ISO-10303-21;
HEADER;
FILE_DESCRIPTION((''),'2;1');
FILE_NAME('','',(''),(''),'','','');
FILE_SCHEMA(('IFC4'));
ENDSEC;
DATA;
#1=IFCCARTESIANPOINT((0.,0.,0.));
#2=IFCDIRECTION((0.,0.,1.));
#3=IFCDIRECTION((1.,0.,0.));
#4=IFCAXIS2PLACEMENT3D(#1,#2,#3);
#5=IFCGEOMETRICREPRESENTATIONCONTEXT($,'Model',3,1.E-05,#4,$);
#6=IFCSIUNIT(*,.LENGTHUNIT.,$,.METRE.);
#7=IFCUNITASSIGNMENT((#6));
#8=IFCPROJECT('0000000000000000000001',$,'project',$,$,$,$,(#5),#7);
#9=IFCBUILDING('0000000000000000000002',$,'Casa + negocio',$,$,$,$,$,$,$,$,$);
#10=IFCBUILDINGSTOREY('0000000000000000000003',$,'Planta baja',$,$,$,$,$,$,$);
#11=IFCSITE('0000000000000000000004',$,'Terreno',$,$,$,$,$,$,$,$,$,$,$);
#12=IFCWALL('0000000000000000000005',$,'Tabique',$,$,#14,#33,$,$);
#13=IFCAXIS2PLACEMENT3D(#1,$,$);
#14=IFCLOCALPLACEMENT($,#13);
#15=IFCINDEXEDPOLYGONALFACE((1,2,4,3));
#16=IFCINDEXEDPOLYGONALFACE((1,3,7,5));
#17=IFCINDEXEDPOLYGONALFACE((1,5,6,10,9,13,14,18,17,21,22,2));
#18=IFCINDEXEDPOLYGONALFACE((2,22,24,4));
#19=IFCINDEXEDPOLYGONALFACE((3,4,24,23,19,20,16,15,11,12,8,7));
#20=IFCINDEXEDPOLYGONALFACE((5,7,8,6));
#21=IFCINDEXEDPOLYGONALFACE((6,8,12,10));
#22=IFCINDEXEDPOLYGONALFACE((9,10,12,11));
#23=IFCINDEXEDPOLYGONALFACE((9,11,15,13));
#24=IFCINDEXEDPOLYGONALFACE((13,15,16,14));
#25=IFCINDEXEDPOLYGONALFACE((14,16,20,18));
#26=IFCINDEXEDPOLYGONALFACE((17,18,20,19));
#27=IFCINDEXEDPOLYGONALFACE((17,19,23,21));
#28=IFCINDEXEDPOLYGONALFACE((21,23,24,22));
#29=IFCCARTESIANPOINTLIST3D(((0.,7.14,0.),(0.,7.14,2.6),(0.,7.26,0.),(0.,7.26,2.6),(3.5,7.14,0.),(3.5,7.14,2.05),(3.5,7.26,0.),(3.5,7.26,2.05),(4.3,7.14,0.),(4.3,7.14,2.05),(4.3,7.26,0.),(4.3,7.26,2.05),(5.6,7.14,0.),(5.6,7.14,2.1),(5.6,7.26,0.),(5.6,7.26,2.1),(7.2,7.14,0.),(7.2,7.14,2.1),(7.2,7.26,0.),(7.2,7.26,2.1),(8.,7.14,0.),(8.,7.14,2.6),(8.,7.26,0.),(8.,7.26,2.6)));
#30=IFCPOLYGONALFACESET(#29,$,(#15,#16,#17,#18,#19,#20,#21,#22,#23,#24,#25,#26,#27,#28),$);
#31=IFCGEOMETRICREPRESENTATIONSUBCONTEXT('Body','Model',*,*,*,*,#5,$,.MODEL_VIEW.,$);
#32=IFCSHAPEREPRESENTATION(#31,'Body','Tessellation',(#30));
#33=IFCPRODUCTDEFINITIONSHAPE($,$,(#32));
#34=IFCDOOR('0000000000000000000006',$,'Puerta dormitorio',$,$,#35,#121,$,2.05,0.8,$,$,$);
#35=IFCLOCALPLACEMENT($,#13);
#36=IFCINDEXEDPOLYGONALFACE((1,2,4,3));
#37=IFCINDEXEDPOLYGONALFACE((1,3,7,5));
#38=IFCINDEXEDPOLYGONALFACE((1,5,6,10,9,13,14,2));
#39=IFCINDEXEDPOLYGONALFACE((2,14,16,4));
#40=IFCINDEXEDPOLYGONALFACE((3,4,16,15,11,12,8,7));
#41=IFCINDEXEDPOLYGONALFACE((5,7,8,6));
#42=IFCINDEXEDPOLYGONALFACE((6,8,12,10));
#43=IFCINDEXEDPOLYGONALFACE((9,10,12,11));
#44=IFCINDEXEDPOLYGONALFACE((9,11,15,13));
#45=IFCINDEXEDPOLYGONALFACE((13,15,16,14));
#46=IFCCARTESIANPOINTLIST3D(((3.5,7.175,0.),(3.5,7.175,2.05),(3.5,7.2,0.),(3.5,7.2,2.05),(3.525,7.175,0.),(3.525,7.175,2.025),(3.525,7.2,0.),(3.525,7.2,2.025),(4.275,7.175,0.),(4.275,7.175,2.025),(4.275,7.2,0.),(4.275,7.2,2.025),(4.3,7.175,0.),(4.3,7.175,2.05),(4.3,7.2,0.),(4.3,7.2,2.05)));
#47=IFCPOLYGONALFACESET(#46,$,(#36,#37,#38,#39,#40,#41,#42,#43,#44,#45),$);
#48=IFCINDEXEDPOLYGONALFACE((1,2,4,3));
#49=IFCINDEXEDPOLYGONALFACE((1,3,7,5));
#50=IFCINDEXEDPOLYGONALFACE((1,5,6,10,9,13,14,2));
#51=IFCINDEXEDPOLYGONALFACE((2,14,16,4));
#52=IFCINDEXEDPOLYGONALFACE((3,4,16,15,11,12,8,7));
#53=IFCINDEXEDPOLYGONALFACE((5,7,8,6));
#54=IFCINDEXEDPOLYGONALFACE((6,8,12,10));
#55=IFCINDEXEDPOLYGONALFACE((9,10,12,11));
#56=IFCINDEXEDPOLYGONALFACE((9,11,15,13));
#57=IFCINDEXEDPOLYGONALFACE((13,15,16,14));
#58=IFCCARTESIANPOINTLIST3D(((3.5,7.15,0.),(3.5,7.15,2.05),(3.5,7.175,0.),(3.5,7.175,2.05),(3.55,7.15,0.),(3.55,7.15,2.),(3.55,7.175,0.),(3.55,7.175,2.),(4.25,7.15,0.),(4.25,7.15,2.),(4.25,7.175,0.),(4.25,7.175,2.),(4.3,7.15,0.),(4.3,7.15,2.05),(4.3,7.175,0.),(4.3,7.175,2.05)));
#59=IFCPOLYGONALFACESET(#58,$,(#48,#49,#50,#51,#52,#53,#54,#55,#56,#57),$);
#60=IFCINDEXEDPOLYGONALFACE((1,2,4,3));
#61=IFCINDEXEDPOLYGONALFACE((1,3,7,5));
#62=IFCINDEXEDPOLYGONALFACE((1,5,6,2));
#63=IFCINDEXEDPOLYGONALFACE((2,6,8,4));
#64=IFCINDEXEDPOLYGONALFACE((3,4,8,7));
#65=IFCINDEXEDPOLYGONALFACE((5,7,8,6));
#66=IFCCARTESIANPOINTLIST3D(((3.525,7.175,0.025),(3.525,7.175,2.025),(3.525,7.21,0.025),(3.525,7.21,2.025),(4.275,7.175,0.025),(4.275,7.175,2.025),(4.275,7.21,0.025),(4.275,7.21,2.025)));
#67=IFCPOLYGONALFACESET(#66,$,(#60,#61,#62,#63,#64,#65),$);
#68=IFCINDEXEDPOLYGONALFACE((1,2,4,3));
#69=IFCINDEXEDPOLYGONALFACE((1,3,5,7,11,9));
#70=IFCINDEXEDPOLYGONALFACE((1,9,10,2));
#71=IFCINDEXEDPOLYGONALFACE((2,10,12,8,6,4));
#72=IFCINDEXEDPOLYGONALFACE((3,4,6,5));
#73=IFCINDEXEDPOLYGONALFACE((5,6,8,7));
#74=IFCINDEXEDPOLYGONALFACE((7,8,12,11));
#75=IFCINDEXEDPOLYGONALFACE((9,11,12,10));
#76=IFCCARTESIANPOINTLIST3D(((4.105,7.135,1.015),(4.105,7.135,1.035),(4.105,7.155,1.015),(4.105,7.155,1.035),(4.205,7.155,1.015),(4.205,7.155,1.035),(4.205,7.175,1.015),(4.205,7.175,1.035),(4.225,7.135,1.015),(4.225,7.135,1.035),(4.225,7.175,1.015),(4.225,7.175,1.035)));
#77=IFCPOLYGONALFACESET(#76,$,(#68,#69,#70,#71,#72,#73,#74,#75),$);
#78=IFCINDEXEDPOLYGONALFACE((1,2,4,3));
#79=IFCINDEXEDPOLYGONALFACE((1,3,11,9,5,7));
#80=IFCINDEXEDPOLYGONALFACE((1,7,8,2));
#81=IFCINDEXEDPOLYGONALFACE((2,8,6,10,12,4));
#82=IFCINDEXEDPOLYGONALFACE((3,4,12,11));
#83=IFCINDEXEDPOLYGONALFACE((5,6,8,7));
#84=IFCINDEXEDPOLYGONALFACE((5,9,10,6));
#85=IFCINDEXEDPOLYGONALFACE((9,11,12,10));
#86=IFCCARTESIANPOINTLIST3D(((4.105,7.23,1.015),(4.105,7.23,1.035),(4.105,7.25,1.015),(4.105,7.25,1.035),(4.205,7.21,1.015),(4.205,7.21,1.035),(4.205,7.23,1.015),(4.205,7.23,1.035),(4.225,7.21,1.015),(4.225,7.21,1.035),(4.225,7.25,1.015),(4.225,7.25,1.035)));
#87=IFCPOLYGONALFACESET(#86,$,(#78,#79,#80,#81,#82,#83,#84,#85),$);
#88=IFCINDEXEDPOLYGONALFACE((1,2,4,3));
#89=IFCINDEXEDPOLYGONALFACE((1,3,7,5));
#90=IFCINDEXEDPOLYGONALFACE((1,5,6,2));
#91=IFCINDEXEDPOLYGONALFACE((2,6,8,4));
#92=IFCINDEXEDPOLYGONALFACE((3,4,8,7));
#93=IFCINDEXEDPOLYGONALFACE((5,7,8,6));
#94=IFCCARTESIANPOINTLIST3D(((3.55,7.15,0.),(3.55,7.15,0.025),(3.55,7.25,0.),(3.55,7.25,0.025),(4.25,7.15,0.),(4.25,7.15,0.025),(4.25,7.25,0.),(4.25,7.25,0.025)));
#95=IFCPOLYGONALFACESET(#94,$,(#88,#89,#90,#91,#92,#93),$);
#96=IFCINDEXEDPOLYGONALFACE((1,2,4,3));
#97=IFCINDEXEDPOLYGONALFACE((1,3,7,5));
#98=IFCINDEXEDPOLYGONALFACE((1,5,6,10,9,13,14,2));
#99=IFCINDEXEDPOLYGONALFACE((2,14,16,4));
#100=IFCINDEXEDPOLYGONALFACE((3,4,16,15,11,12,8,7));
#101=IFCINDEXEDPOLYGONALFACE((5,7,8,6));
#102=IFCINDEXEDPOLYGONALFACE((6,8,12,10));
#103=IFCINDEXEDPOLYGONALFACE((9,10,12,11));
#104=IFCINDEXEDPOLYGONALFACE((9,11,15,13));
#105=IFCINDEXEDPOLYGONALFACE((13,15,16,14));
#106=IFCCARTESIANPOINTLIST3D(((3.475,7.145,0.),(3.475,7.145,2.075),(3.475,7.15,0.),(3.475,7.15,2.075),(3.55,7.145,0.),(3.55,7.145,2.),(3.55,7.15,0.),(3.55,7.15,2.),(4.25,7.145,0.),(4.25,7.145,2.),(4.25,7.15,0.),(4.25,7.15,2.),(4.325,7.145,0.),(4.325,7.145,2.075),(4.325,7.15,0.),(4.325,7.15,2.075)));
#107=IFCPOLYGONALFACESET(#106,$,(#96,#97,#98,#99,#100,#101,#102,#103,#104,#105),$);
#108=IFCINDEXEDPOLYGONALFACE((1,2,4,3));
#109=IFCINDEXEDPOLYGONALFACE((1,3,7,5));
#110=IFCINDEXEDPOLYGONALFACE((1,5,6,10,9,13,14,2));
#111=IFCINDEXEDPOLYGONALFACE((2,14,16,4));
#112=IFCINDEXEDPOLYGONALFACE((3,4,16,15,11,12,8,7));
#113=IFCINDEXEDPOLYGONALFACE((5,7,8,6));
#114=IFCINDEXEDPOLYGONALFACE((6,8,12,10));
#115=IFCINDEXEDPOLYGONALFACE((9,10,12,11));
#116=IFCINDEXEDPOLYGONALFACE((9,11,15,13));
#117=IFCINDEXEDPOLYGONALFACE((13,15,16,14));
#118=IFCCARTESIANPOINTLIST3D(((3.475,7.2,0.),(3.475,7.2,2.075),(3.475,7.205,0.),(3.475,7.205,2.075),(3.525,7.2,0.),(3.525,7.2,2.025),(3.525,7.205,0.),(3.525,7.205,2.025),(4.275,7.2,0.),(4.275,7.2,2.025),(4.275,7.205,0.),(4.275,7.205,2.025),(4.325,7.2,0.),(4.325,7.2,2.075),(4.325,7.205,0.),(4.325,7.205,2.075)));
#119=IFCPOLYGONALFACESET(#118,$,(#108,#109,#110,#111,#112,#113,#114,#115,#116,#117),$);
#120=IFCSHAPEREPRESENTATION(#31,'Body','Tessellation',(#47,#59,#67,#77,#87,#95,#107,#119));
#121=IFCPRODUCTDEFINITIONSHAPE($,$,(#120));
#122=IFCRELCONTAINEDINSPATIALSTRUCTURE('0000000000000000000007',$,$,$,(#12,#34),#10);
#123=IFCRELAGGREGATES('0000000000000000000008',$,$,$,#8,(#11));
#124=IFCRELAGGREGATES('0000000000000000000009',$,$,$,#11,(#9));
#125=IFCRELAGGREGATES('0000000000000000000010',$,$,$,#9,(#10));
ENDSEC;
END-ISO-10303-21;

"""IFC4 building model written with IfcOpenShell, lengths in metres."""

from ifc_helpers import new_model, si_unit, frame, origin_with_axes, place, context, subcontext, project, spatial, line, indexed_curve, outline, extrude, element, fill, save


model = new_model("IFC4")

# Units and contexts
model_context = context("Model", 3, precision=1e-05, world=origin_with_axes())
body_context = subcontext(model_context, "Body", "Model", "MODEL_VIEW")
ifc_project = project(units=[si_unit("LENGTHUNIT", "METRE")], contexts=[model_context])

# Site, building, storey
site = spatial("IfcSite", under=ifc_project, Name="Terreno")
building = spatial("IfcBuilding", under=site, Name="Casa + negocio")
storey = spatial("IfcBuildingStorey", under=building, Name="Planta baja")

# Wall, openings, door
wall_1_placement = place(None, frame((0.0, 7.2, 0.0), z_axis=(0.0, 0.0, 1.0), x_axis=(1.0, 0.0, 0.0)))
wall_1 = element("IfcWall", 1, at=wall_1_placement, inside=storey, Name="Tabique", context=body_context, shape_type="SweptSolid", body=[
    extrude(outline(indexed_curve([(0.0, 0.0), (0.0, 0.12), (8.0, 0.12), (8.0, 0.0), (0.0, 0.0)], self_intersect=False)), frame((0.0, -0.06, 0.0), z_axis=(0.0, 0.0, 1.0), x_axis=(1.0, 0.0, 0.0)), (0.0, 0.0, 1.0), 2.6),
])
opening_1_placement = place(wall_1_placement, frame((3.5, 0.0, 0.0), z_axis=(0.0, 0.0, 1.0), x_axis=(1.0, 0.0, 0.0)))
opening_1 = element("IfcOpeningElement", 2, at=opening_1_placement, cuts=wall_1, context=body_context, shape_type="SweptSolid", body=[
    extrude(outline(indexed_curve([(0.0, 0.0), (0.0, 0.22), (0.8, 0.22), (0.8, 0.0), (0.0, 0.0)], self_intersect=False)), frame((0.0, -0.11, 0.0), z_axis=(0.0, 0.0, 1.0), x_axis=(1.0, 0.0, 0.0)), (0.0, 0.0, 1.0), 2.05),
])
opening_2_placement = place(wall_1_placement, frame((5.6, 0.0, 0.0), z_axis=(0.0, 0.0, 1.0), x_axis=(1.0, 0.0, 0.0)))
element("IfcOpeningElement", 3, at=opening_2_placement, cuts=wall_1, context=body_context, shape_type="SweptSolid", body=[
    extrude(outline(indexed_curve([(0.0, 0.0), (0.0, 0.22), (1.6, 0.22), (1.6, 0.0), (0.0, 0.0)], self_intersect=False)), frame((0.0, -0.11, 0.0), z_axis=(0.0, 0.0, 1.0), x_axis=(1.0, 0.0, 0.0)), (0.0, 0.0, 1.0), 2.1),
])
door_1_placement = place(opening_1_placement, frame((0.0, -0.05, 0.0), z_axis=(0.0, 0.0, 1.0), x_axis=(1.0, 0.0, 0.0)))
door_1 = element("IfcDoor", 4, at=door_1_placement, inside=storey, Name="Puerta dormitorio", OverallHeight=2.05, OverallWidth=0.8, context=body_context, shape_type="SweptSolid", body=[
    extrude(outline(indexed_curve([(0.0, 0.0), (0.0, 2.05), (0.8, 2.05), (0.8, 0.0), (0.775, 0.0), (0.775, 2.025), (0.025, 2.025), (0.025, 0.0)], segments=[line(1, 2, 3, 4, 5, 6, 7, 8, 1)])), frame((0.0, 0.025, 0.0), z_axis=(0.0, -1.0, 0.0), x_axis=(1.0, 0.0, 0.0)), (0.0, 0.0, -1.0), 0.025),
    extrude(outline(indexed_curve([(0.0, 0.0), (0.0, 2.05), (0.8, 2.05), (0.8, 0.0), (0.75, 0.0), (0.75, 2.0), (0.05, 2.0), (0.05, 0.0)], segments=[line(1, 2, 3, 4, 5, 6, 7, 8, 1)])), frame((0.0, 0.0, 0.0), z_axis=(0.0, -1.0, 0.0), x_axis=(1.0, 0.0, 0.0)), (0.0, 0.0, -1.0), 0.025),
    extrude(outline(indexed_curve([(0.0, 0.0), (0.75, 0.0), (0.75, 0.035), (0.0, 0.035)], segments=[line(1, 2, 3, 4, 1)])), frame((0.025, 0.025, 0.025), z_axis=(0.0, 0.0, 1.0), x_axis=(1.0, 0.0, 0.0)), (0.0, 0.0, 1.0), 2.0),
    extrude(outline(indexed_curve([(0.0, 0.0), (0.0, -0.04), (-0.12, -0.04), (-0.12, -0.02), (-0.02, -0.02), (-0.02, 0.0)], segments=[line(1, 2, 3, 4, 5, 6, 1)])), frame((0.725, 0.025, 1.015), z_axis=(0.0, 0.0, 1.0), x_axis=(1.0, 0.0, 0.0)), (0.0, 0.0, 1.0), 0.02),
    extrude(outline(indexed_curve([(0.0, 0.0), (0.0, 0.04), (-0.12, 0.04), (-0.12, 0.02), (-0.02, 0.02), (-0.02, 0.0)], segments=[line(1, 2, 3, 4, 5, 6, 1)])), frame((0.725, 0.06, 1.015), z_axis=(0.0, 0.0, 1.0), x_axis=(1.0, 0.0, 0.0)), (0.0, 0.0, 1.0), 0.02),
    extrude(outline(indexed_curve([(0.0, 0.0), (0.7, 0.0), (0.7, 0.1), (0.0, 0.1)], segments=[line(1, 2, 3, 4, 1)])), frame((0.05, 0.0, 0.0), z_axis=(0.0, 0.0, 1.0), x_axis=(1.0, 0.0, 0.0)), (0.0, 0.0, 1.0), 0.025),
    extrude(outline(indexed_curve([(0.0, 0.0), (0.0, 2.075), (0.85, 2.075), (0.85, 0.0), (0.775, 0.0), (0.775, 2.0), (0.075, 2.0), (0.075, 0.0)], segments=[line(1, 2, 3, 4, 5, 6, 7, 8, 1)])), frame((-0.025, -0.005, 0.0), z_axis=(0.0, -1.0, 0.0), x_axis=(1.0, 0.0, 0.0)), (0.0, 0.0, -1.0), 0.005),
    extrude(outline(indexed_curve([(0.0, 0.0), (0.0, 2.075), (0.85, 2.075), (0.85, 0.0), (0.8, 0.0), (0.8, 2.025), (0.05, 2.025), (0.05, 0.0)], segments=[line(1, 2, 3, 4, 5, 6, 7, 8, 1)])), frame((-0.025, 0.05, 0.0), z_axis=(0.0, -1.0, 0.0), x_axis=(1.0, 0.0, 0.0)), (0.0, 0.0, -1.0), 0.005),
])
fill(opening_1, door_1)

save(model, "model.ifc")
